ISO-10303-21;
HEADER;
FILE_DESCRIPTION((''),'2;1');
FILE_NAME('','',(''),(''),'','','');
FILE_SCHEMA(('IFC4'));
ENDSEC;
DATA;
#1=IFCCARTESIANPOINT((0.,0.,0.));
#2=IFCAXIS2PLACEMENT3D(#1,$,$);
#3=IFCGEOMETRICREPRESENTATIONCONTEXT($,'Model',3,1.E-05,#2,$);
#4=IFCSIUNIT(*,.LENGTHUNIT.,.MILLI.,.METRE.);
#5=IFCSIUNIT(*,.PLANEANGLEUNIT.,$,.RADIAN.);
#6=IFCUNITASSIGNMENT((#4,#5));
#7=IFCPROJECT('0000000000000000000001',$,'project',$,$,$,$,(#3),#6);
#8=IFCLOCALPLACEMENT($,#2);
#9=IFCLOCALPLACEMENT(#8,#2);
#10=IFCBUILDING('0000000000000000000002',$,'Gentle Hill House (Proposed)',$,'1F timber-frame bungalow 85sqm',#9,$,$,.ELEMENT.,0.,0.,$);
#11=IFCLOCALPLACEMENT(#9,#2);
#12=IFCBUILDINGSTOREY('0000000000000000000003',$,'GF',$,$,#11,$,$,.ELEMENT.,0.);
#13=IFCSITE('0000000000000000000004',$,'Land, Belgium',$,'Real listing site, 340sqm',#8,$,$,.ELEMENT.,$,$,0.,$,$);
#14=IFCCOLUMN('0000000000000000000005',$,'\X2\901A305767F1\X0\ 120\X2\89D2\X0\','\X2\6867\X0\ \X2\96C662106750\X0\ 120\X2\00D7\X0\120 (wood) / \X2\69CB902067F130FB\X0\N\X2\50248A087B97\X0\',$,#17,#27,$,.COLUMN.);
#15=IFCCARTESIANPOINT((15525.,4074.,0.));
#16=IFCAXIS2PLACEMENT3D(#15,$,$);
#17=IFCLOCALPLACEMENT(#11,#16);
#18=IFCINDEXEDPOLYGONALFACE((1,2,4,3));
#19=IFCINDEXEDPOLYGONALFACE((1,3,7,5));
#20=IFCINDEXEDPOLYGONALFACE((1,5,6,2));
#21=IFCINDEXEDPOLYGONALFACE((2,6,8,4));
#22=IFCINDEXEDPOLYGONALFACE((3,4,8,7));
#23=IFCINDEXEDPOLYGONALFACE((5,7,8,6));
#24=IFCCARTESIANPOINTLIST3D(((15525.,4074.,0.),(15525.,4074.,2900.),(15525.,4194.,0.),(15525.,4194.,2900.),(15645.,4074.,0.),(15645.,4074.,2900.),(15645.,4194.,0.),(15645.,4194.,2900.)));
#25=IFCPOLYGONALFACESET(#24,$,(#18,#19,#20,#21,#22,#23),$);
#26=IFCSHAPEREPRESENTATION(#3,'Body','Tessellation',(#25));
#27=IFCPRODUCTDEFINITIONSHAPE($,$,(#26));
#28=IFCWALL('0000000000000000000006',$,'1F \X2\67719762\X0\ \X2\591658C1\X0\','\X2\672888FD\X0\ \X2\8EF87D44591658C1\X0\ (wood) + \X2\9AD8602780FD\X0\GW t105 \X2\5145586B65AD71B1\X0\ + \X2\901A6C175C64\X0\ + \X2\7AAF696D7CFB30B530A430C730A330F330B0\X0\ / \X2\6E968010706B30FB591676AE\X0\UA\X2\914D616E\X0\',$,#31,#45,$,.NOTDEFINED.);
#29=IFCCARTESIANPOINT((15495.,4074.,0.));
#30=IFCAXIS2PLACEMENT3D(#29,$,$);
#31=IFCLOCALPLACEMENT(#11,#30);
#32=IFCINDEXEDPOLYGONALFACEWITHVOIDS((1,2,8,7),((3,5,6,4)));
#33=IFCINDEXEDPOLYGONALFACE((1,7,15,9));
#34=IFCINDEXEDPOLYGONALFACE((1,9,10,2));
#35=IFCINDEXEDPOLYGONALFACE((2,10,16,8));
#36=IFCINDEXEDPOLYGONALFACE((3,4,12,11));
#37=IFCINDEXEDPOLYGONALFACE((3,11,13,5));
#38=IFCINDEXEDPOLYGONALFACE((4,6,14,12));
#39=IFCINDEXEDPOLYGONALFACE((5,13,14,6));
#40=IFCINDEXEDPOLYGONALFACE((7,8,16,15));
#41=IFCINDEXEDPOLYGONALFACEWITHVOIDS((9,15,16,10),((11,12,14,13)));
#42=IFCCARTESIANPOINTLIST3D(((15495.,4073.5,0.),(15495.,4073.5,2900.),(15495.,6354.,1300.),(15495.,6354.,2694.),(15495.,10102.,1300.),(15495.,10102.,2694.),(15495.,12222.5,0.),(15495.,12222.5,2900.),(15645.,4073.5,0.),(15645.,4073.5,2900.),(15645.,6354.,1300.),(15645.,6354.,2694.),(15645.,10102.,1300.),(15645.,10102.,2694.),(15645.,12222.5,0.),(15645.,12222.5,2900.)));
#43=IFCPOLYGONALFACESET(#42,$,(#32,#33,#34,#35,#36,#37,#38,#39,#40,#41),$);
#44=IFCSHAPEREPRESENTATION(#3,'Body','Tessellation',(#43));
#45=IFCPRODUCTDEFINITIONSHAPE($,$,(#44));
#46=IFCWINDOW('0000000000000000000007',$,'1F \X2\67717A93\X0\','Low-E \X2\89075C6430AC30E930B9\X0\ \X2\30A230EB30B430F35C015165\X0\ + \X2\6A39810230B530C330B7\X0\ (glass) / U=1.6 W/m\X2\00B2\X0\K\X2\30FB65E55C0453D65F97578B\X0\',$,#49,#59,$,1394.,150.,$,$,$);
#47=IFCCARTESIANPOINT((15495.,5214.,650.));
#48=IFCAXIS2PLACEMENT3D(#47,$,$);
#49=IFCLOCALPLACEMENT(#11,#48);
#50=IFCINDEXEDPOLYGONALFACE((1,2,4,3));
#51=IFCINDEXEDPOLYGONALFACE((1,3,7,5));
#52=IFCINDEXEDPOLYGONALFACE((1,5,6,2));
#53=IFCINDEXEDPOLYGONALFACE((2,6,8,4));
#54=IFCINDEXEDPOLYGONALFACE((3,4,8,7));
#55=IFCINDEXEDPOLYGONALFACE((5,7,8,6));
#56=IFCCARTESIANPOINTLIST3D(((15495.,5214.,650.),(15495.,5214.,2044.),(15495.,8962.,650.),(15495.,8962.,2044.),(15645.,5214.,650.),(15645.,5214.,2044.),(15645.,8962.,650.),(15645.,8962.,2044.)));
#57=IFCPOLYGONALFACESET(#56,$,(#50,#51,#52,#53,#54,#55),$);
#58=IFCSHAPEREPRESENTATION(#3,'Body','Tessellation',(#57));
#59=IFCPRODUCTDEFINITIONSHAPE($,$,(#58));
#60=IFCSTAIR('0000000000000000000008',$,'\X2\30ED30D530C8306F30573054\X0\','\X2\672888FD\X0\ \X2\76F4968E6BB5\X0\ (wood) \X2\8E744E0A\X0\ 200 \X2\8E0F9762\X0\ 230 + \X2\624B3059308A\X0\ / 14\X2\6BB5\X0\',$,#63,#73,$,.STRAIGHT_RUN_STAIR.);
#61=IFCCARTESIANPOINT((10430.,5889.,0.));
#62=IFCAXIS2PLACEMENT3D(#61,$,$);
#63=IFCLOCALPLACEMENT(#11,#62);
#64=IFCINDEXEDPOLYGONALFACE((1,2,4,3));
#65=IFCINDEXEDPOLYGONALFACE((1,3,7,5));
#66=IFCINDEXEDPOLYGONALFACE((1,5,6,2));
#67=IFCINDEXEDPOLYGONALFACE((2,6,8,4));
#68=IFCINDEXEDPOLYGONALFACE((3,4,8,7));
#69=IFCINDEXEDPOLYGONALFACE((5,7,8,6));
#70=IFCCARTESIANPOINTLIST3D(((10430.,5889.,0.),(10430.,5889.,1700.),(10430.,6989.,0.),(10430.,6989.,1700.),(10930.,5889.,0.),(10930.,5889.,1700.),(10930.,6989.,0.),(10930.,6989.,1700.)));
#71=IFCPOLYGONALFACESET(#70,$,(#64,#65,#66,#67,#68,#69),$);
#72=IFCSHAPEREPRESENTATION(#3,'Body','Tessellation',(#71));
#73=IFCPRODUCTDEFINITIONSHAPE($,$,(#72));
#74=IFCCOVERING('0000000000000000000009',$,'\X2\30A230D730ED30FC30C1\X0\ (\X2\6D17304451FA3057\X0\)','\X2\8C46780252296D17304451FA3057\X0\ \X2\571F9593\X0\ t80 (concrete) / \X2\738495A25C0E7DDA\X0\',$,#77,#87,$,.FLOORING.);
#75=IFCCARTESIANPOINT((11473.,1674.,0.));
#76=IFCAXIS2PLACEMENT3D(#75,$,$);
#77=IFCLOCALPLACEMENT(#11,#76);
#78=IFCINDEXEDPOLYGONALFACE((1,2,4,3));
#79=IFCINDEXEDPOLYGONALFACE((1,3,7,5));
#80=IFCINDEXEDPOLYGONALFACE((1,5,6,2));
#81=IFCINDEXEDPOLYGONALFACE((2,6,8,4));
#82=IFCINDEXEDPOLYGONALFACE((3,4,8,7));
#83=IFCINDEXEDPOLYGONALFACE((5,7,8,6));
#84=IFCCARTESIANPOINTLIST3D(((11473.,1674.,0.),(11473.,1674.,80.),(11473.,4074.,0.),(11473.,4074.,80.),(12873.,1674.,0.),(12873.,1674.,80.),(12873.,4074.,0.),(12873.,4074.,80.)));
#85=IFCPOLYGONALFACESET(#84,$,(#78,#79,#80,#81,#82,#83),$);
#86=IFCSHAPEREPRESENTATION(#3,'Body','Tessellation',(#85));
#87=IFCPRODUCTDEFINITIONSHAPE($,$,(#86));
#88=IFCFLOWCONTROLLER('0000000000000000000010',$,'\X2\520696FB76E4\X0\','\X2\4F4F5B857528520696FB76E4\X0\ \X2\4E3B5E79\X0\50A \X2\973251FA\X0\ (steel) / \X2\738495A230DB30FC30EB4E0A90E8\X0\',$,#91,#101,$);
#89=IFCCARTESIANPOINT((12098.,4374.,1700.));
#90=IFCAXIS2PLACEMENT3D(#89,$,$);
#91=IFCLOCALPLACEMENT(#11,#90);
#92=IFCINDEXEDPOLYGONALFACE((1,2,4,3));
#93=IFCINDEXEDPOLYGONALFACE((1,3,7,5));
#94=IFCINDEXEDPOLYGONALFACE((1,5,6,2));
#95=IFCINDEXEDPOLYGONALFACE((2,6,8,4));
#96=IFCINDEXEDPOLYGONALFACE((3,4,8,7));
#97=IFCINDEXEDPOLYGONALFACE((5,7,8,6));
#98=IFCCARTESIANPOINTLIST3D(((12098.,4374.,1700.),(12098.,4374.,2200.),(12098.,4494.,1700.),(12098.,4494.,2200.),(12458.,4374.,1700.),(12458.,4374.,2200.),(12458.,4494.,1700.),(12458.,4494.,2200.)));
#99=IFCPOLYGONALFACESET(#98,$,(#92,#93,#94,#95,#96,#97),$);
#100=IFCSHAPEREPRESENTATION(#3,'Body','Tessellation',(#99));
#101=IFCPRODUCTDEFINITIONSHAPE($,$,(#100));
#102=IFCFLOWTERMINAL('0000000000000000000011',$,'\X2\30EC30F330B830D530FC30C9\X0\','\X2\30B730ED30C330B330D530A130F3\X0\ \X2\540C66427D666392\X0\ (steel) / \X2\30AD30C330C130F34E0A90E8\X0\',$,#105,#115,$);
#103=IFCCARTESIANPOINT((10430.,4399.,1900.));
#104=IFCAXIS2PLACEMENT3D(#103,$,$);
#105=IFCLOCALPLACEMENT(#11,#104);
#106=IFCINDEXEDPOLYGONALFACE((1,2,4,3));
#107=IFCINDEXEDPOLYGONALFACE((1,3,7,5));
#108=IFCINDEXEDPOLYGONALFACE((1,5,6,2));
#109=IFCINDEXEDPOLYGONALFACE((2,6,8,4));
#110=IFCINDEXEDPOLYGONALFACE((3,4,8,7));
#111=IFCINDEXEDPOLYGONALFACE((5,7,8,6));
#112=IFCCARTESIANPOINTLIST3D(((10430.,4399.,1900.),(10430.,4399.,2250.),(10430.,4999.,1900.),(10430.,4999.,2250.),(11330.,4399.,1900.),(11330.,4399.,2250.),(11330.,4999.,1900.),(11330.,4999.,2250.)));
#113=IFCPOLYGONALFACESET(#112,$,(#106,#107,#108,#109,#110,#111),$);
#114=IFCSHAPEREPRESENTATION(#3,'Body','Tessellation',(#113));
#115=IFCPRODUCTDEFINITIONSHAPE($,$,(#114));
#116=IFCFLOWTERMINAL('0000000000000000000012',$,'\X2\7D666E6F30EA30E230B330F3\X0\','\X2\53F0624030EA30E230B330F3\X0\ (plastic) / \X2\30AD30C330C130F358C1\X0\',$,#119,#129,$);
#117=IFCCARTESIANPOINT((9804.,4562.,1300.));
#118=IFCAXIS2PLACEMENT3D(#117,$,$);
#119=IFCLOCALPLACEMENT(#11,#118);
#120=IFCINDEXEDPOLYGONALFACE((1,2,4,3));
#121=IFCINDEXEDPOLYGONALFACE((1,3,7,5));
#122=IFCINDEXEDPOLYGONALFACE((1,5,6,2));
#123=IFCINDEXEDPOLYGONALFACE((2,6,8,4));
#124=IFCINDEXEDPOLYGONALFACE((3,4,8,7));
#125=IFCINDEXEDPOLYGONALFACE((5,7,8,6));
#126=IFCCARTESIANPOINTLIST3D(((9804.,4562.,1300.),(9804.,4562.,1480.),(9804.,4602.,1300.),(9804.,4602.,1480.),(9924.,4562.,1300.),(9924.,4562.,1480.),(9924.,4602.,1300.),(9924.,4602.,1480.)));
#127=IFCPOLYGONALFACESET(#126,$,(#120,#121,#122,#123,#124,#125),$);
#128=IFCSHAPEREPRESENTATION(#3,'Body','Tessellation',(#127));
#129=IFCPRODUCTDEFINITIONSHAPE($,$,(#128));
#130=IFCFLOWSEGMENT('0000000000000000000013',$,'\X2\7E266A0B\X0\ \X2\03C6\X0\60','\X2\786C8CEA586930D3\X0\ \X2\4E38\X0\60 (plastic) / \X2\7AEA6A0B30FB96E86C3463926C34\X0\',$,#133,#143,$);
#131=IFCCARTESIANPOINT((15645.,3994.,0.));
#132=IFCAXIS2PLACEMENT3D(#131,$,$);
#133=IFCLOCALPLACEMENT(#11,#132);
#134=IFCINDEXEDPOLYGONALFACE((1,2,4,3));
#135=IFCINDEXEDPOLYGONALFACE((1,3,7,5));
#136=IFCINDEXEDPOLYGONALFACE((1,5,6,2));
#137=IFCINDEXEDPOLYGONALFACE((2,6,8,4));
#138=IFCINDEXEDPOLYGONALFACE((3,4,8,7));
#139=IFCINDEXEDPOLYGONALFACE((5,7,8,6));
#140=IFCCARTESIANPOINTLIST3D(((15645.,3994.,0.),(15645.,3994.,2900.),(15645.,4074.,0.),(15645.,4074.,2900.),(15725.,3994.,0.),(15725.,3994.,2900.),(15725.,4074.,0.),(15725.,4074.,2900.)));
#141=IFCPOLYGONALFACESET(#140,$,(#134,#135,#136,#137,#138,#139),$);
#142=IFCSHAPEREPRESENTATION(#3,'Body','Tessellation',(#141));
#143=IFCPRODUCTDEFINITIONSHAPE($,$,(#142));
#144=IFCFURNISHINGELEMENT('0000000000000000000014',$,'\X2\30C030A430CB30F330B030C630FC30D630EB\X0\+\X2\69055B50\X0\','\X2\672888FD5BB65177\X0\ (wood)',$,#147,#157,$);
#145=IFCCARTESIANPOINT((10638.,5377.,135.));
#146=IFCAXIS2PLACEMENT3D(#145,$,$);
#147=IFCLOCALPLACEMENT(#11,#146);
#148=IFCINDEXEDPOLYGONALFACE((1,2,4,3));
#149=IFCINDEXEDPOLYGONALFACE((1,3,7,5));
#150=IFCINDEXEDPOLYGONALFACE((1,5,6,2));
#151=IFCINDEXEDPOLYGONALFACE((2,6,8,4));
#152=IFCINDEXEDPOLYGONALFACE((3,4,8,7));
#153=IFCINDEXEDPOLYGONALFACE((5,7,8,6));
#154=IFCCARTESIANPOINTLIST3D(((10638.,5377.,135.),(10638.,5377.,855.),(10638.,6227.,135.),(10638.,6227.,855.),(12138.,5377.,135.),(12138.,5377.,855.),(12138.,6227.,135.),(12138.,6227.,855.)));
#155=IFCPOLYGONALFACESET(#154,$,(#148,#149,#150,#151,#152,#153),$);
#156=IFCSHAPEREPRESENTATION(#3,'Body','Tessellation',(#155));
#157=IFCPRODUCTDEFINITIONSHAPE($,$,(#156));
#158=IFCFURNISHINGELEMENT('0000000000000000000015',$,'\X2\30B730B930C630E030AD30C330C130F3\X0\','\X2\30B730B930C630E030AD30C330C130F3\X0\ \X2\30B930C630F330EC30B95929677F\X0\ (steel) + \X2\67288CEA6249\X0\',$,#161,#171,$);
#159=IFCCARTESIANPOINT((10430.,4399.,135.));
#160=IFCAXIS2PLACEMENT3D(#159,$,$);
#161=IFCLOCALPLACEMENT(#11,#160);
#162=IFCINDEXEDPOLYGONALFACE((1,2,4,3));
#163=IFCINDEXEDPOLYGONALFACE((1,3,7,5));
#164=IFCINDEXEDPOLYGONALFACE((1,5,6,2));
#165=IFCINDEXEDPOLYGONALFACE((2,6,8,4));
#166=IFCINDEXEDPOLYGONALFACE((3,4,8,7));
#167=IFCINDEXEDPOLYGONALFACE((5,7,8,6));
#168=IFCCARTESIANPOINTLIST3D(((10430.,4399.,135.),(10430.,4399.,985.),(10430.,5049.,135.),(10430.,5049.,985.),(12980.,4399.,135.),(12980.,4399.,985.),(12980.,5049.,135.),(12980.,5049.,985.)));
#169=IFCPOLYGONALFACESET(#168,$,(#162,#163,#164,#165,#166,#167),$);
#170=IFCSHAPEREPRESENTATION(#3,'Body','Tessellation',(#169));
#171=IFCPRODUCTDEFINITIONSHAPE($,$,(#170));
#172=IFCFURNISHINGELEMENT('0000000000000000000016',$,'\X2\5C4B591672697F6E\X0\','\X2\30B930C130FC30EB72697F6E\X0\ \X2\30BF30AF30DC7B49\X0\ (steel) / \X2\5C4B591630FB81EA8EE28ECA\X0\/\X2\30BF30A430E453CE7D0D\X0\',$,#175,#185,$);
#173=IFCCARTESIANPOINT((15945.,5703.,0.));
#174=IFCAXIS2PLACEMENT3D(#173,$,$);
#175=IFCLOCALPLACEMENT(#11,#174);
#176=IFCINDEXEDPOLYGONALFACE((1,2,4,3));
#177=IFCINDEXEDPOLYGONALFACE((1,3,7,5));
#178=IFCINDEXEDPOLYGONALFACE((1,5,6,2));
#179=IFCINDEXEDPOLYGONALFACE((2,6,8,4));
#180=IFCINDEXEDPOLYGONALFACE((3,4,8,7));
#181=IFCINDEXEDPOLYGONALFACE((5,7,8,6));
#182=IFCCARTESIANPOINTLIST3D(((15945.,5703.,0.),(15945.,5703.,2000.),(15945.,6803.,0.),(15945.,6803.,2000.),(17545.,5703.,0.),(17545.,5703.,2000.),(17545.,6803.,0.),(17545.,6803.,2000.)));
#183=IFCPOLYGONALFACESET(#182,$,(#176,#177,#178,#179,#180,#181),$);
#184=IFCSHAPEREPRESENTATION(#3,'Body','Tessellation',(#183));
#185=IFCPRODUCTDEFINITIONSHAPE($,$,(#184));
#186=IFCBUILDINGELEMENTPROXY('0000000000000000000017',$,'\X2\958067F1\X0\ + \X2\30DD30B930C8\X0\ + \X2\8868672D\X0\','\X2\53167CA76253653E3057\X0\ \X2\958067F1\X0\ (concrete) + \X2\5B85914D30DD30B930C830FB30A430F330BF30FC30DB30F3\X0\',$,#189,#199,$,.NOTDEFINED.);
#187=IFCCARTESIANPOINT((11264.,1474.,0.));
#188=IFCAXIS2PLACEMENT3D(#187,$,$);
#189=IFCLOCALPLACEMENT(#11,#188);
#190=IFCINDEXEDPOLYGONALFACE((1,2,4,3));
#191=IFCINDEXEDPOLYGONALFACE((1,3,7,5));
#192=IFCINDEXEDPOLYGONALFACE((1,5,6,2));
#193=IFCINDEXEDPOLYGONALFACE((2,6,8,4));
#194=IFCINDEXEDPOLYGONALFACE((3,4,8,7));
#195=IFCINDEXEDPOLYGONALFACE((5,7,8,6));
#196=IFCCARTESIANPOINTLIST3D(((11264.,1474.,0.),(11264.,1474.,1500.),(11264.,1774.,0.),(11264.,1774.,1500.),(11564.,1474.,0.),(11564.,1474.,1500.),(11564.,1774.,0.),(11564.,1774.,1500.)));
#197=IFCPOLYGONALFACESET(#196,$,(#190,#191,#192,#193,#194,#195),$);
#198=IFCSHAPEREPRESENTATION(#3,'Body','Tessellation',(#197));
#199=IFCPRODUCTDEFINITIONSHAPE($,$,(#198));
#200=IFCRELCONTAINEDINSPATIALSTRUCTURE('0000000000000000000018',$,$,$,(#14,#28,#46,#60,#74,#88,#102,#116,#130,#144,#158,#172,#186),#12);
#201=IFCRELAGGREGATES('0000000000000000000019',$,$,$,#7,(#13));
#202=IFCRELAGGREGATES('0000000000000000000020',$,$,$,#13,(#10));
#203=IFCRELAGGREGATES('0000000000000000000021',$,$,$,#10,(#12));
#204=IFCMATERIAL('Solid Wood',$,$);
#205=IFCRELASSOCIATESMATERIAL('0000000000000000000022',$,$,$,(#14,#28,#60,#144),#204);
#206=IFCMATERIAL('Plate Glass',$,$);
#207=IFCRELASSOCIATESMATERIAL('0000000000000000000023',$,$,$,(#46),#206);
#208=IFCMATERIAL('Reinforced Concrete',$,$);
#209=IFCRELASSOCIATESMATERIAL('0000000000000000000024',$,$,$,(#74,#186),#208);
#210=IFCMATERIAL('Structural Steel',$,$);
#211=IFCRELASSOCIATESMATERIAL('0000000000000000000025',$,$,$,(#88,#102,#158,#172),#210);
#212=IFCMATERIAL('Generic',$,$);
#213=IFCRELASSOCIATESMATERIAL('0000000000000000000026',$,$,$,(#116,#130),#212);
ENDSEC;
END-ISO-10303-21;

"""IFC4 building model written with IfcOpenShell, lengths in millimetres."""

from ifc_helpers import new_model, si_unit, frame, frame_2d, origin, place, context, project, spatial, rectangle, extrude, material, element, fill, save


model = new_model("IFC4")

# Units and contexts
model_context = context("Model", 3, precision=1e-05, world=origin())
ifc_project = project(units=[si_unit("LENGTHUNIT", "METRE", prefix="MILLI"), si_unit("PLANEANGLEUNIT", "RADIAN")], contexts=[model_context])

# Site, building, storey
site_placement = place(None, origin())
site = spatial("IfcSite", under=ifc_project, at=site_placement, Name="Land, Belgium", ObjectType="Real listing site, 340sqm", CompositionType="ELEMENT", RefElevation=0.0)
building_placement = place(site_placement, origin())
building = spatial("IfcBuilding", under=site, at=building_placement, Name="Gentle Hill House (Proposed)", ObjectType="1F timber-frame bungalow 85sqm", CompositionType="ELEMENT", ElevationOfRefHeight=0.0, ElevationOfTerrain=0.0)
storey_placement = place(building_placement, origin())
storey = spatial("IfcBuildingStorey", under=building, at=storey_placement, Name="GF", CompositionType="ELEMENT", Elevation=0.0)

# Column
ifc_material_1 = material(Name="Solid Wood")
column_1_placement = place(storey_placement, frame((15525.0, 4074.0, 0.0)))
element("IfcColumn", 1, at=column_1_placement, inside=storey, material=ifc_material_1, Name="通し柱 120角", Description="桧 集成材 120×120 (wood) / 構造柱・N値計算", PredefinedType="COLUMN", context=model_context, shape_type="SweptSolid", body=[
    extrude(rectangle(XDim=120.0, YDim=120.0, at=frame_2d((60.0, 60.0))), frame((15525.0, 4074.0, 0.0)), (0.0, 0.0, 1.0), 2900.0),
])

# Wall, opening, window
wall_1_placement = place(storey_placement, frame((15495.0, 4074.0, 0.0)))
wall_1 = element("IfcWall", 2, at=wall_1_placement, inside=storey, material=ifc_material_1, Name="1F 東面 外壁", Description="木製 軸組外壁 (wood) + 高性能GW t105 充填断熱 + 通気層 + 窯業系サイディング / 準耐火・外皮UA配慮", PredefinedType="NOTDEFINED", context=model_context, shape_type="SweptSolid", body=[
    extrude(rectangle(XDim=150.0, YDim=8149.0, at=frame_2d((75.0, 4074.0))), frame((15495.0, 4074.0, 0.0)), (0.0, 0.0, 1.0), 2900.0),
])
opening_placement = place(storey_placement, frame((15495.0, 5214.0, 650.0)))
opening = element("IfcOpeningElement", 3, at=opening_placement, cuts=wall_1, PredefinedType="NOTDEFINED", context=model_context, shape_type="SweptSolid", body=[
    extrude(rectangle(XDim=150.0, YDim=3748.0, at=frame_2d((75.0, 1874.0))), frame((15495.0, 5214.0, 650.0)), (0.0, 0.0, 1.0), 1394.0),
])
ifc_material_2 = material(Name="Plate Glass")
window_placement = place(storey_placement, frame((15495.0, 5214.0, 650.0)))
window = element("IfcWindow", 4, at=window_placement, inside=storey, material=ifc_material_2, Name="1F 東窓", Description="Low-E 複層ガラス アルゴン封入 + 樹脂サッシ (glass) / U=1.6 W/m²K・日射取得型", OverallHeight=1394.0, OverallWidth=150.0, context=model_context, shape_type="SweptSolid", body=[
    extrude(rectangle(XDim=150.0, YDim=3748.0, at=frame_2d((75.0, 1874.0))), frame((15495.0, 5214.0, 650.0)), (0.0, 0.0, 1.0), 1394.0),
])
fill(opening, window)

# Stair
stair_placement = place(storey_placement, frame((10430.0, 5889.0, 0.0)))
element("IfcStair", 5, at=stair_placement, inside=storey, material=ifc_material_1, Name="ロフトはしご", Description="木製 直階段 (wood) 蹴上 200 踏面 230 + 手すり / 14段", PredefinedType="STRAIGHT_RUN_STAIR", context=model_context, shape_type="SweptSolid", body=[
    extrude(rectangle(XDim=500.0, YDim=1100.0, at=frame_2d((250.0, 550.0))), frame((10430.0, 5889.0, 0.0)), (0.0, 0.0, 1.0), 1700.0),
])

# Covering
ifc_material_3 = material(Name="Reinforced Concrete")
covering_placement = place(storey_placement, frame((11473.0, 1674.0, 0.0)))
element("IfcCovering", 6, at=covering_placement, inside=storey, material=ifc_material_3, Name="アプローチ (洗い出し)", Description="豆砂利洗い出し 土間 t80 (concrete) / 玄関導線", PredefinedType="FLOORING", context=model_context, shape_type="SweptSolid", body=[
    extrude(rectangle(XDim=1400.0, YDim=2400.0, at=frame_2d((700.0, 1200.0))), frame((11473.0, 1674.0, 0.0)), (0.0, 0.0, 1.0), 80.0),
])

# Flow controller
ifc_material_4 = material(Name="Structural Steel")
flow_controller_placement = place(storey_placement, frame((12098.0, 4374.0, 1700.0)))
element("IfcFlowController", 7, at=flow_controller_placement, inside=storey, material=ifc_material_4, Name="分電盤", Description="住宅用分電盤 主幹50A 露出 (steel) / 玄関ホール上部", context=model_context, shape_type="SweptSolid", body=[
    extrude(rectangle(XDim=360.0, YDim=120.0, at=frame_2d((180.0, 60.0))), frame((12098.0, 4374.0, 1700.0)), (0.0, 0.0, 1.0), 500.0),
])

# Flow terminals
flow_terminal_1_placement = place(storey_placement, frame((10430.0, 4399.0, 1900.0)))
element("IfcFlowTerminal", 8, at=flow_terminal_1_placement, inside=storey, material=ifc_material_4, Name="レンジフード", Description="シロッコファン 同時給排 (steel) / キッチン上部", context=model_context, shape_type="SweptSolid", body=[
    extrude(rectangle(XDim=900.0, YDim=600.0, at=frame_2d((450.0, 300.0))), frame((10430.0, 4399.0, 1900.0)), (0.0, 0.0, 1.0), 350.0),
])
ifc_material_5 = material(Name="Generic")
flow_terminal_2_placement = place(storey_placement, frame((9804.0, 4562.0, 1300.0)))
element("IfcFlowTerminal", 9, at=flow_terminal_2_placement, inside=storey, material=ifc_material_5, Name="給湯リモコン", Description="台所リモコン (plastic) / キッチン壁", context=model_context, shape_type="SweptSolid", body=[
    extrude(rectangle(XDim=120.0, YDim=40.0, at=frame_2d((60.0, 20.0))), frame((9804.0, 4562.0, 1300.0)), (0.0, 0.0, 1.0), 180.0),
])

# Flow segment
flow_segment_placement = place(storey_placement, frame((15645.0, 3994.0, 0.0)))
element("IfcFlowSegment", 10, at=flow_segment_placement, inside=storey, material=ifc_material_5, Name="縦樋 φ60", Description="硬質塩ビ 丸60 (plastic) / 竪樋・雨水排水", context=model_context, shape_type="SweptSolid", body=[
    extrude(rectangle(XDim=80.0, YDim=80.0, at=frame_2d((40.0, 40.0))), frame((15645.0, 3994.0, 0.0)), (0.0, 0.0, 1.0), 2900.0),
])

# Furnishing elements
furnishing_1_placement = place(storey_placement, frame((10638.0, 5377.0, 135.0)))
element("IfcFurnishingElement", 11, at=furnishing_1_placement, inside=storey, material=ifc_material_1, Name="ダイニングテーブル+椅子", Description="木製家具 (wood)", context=model_context, shape_type="SweptSolid", body=[
    extrude(rectangle(XDim=1500.0, YDim=850.0, at=frame_2d((750.0, 425.0))), frame((10638.0, 5377.0, 135.0)), (0.0, 0.0, 1.0), 720.0),
])
furnishing_2_placement = place(storey_placement, frame((10430.0, 4399.0, 135.0)))
element("IfcFurnishingElement", 12, at=furnishing_2_placement, inside=storey, material=ifc_material_4, Name="システムキッチン", Description="システムキッチン ステンレス天板 (steel) + 木質扉", context=model_context, shape_type="SweptSolid", body=[
    extrude(rectangle(XDim=2550.0, YDim=650.0, at=frame_2d((1275.0, 325.0))), frame((10430.0, 4399.0, 135.0)), (0.0, 0.0, 1.0), 850.0),
])
furnishing_3_placement = place(storey_placement, frame((15945.0, 5703.0, 0.0)))
element("IfcFurnishingElement", 13, at=furnishing_3_placement, inside=storey, material=ifc_material_4, Name="屋外物置", Description="スチール物置 タクボ等 (steel) / 屋外・自転車/タイヤ収納", context=model_context, shape_type="SweptSolid", body=[
    extrude(rectangle(XDim=1600.0, YDim=1100.0, at=frame_2d((800.0, 550.0))), frame((15945.0, 5703.0, 0.0)), (0.0, 0.0, 1.0), 2000.0),
])

# Building element proxy
proxy_placement = place(storey_placement, frame((11264.0, 1474.0, 0.0)))
element("IfcBuildingElementProxy", 14, at=proxy_placement, inside=storey, material=ifc_material_3, Name="門柱 + ポスト + 表札", Description="化粧打放し 門柱 (concrete) + 宅配ポスト・インターホン", PredefinedType="NOTDEFINED", context=model_context, shape_type="SweptSolid", body=[
    extrude(rectangle(XDim=300.0, YDim=300.0, at=frame_2d((150.0, 150.0))), frame((11264.0, 1474.0, 0.0)), (0.0, 0.0, 1.0), 1500.0),
])

save(model, "model.ifc")
